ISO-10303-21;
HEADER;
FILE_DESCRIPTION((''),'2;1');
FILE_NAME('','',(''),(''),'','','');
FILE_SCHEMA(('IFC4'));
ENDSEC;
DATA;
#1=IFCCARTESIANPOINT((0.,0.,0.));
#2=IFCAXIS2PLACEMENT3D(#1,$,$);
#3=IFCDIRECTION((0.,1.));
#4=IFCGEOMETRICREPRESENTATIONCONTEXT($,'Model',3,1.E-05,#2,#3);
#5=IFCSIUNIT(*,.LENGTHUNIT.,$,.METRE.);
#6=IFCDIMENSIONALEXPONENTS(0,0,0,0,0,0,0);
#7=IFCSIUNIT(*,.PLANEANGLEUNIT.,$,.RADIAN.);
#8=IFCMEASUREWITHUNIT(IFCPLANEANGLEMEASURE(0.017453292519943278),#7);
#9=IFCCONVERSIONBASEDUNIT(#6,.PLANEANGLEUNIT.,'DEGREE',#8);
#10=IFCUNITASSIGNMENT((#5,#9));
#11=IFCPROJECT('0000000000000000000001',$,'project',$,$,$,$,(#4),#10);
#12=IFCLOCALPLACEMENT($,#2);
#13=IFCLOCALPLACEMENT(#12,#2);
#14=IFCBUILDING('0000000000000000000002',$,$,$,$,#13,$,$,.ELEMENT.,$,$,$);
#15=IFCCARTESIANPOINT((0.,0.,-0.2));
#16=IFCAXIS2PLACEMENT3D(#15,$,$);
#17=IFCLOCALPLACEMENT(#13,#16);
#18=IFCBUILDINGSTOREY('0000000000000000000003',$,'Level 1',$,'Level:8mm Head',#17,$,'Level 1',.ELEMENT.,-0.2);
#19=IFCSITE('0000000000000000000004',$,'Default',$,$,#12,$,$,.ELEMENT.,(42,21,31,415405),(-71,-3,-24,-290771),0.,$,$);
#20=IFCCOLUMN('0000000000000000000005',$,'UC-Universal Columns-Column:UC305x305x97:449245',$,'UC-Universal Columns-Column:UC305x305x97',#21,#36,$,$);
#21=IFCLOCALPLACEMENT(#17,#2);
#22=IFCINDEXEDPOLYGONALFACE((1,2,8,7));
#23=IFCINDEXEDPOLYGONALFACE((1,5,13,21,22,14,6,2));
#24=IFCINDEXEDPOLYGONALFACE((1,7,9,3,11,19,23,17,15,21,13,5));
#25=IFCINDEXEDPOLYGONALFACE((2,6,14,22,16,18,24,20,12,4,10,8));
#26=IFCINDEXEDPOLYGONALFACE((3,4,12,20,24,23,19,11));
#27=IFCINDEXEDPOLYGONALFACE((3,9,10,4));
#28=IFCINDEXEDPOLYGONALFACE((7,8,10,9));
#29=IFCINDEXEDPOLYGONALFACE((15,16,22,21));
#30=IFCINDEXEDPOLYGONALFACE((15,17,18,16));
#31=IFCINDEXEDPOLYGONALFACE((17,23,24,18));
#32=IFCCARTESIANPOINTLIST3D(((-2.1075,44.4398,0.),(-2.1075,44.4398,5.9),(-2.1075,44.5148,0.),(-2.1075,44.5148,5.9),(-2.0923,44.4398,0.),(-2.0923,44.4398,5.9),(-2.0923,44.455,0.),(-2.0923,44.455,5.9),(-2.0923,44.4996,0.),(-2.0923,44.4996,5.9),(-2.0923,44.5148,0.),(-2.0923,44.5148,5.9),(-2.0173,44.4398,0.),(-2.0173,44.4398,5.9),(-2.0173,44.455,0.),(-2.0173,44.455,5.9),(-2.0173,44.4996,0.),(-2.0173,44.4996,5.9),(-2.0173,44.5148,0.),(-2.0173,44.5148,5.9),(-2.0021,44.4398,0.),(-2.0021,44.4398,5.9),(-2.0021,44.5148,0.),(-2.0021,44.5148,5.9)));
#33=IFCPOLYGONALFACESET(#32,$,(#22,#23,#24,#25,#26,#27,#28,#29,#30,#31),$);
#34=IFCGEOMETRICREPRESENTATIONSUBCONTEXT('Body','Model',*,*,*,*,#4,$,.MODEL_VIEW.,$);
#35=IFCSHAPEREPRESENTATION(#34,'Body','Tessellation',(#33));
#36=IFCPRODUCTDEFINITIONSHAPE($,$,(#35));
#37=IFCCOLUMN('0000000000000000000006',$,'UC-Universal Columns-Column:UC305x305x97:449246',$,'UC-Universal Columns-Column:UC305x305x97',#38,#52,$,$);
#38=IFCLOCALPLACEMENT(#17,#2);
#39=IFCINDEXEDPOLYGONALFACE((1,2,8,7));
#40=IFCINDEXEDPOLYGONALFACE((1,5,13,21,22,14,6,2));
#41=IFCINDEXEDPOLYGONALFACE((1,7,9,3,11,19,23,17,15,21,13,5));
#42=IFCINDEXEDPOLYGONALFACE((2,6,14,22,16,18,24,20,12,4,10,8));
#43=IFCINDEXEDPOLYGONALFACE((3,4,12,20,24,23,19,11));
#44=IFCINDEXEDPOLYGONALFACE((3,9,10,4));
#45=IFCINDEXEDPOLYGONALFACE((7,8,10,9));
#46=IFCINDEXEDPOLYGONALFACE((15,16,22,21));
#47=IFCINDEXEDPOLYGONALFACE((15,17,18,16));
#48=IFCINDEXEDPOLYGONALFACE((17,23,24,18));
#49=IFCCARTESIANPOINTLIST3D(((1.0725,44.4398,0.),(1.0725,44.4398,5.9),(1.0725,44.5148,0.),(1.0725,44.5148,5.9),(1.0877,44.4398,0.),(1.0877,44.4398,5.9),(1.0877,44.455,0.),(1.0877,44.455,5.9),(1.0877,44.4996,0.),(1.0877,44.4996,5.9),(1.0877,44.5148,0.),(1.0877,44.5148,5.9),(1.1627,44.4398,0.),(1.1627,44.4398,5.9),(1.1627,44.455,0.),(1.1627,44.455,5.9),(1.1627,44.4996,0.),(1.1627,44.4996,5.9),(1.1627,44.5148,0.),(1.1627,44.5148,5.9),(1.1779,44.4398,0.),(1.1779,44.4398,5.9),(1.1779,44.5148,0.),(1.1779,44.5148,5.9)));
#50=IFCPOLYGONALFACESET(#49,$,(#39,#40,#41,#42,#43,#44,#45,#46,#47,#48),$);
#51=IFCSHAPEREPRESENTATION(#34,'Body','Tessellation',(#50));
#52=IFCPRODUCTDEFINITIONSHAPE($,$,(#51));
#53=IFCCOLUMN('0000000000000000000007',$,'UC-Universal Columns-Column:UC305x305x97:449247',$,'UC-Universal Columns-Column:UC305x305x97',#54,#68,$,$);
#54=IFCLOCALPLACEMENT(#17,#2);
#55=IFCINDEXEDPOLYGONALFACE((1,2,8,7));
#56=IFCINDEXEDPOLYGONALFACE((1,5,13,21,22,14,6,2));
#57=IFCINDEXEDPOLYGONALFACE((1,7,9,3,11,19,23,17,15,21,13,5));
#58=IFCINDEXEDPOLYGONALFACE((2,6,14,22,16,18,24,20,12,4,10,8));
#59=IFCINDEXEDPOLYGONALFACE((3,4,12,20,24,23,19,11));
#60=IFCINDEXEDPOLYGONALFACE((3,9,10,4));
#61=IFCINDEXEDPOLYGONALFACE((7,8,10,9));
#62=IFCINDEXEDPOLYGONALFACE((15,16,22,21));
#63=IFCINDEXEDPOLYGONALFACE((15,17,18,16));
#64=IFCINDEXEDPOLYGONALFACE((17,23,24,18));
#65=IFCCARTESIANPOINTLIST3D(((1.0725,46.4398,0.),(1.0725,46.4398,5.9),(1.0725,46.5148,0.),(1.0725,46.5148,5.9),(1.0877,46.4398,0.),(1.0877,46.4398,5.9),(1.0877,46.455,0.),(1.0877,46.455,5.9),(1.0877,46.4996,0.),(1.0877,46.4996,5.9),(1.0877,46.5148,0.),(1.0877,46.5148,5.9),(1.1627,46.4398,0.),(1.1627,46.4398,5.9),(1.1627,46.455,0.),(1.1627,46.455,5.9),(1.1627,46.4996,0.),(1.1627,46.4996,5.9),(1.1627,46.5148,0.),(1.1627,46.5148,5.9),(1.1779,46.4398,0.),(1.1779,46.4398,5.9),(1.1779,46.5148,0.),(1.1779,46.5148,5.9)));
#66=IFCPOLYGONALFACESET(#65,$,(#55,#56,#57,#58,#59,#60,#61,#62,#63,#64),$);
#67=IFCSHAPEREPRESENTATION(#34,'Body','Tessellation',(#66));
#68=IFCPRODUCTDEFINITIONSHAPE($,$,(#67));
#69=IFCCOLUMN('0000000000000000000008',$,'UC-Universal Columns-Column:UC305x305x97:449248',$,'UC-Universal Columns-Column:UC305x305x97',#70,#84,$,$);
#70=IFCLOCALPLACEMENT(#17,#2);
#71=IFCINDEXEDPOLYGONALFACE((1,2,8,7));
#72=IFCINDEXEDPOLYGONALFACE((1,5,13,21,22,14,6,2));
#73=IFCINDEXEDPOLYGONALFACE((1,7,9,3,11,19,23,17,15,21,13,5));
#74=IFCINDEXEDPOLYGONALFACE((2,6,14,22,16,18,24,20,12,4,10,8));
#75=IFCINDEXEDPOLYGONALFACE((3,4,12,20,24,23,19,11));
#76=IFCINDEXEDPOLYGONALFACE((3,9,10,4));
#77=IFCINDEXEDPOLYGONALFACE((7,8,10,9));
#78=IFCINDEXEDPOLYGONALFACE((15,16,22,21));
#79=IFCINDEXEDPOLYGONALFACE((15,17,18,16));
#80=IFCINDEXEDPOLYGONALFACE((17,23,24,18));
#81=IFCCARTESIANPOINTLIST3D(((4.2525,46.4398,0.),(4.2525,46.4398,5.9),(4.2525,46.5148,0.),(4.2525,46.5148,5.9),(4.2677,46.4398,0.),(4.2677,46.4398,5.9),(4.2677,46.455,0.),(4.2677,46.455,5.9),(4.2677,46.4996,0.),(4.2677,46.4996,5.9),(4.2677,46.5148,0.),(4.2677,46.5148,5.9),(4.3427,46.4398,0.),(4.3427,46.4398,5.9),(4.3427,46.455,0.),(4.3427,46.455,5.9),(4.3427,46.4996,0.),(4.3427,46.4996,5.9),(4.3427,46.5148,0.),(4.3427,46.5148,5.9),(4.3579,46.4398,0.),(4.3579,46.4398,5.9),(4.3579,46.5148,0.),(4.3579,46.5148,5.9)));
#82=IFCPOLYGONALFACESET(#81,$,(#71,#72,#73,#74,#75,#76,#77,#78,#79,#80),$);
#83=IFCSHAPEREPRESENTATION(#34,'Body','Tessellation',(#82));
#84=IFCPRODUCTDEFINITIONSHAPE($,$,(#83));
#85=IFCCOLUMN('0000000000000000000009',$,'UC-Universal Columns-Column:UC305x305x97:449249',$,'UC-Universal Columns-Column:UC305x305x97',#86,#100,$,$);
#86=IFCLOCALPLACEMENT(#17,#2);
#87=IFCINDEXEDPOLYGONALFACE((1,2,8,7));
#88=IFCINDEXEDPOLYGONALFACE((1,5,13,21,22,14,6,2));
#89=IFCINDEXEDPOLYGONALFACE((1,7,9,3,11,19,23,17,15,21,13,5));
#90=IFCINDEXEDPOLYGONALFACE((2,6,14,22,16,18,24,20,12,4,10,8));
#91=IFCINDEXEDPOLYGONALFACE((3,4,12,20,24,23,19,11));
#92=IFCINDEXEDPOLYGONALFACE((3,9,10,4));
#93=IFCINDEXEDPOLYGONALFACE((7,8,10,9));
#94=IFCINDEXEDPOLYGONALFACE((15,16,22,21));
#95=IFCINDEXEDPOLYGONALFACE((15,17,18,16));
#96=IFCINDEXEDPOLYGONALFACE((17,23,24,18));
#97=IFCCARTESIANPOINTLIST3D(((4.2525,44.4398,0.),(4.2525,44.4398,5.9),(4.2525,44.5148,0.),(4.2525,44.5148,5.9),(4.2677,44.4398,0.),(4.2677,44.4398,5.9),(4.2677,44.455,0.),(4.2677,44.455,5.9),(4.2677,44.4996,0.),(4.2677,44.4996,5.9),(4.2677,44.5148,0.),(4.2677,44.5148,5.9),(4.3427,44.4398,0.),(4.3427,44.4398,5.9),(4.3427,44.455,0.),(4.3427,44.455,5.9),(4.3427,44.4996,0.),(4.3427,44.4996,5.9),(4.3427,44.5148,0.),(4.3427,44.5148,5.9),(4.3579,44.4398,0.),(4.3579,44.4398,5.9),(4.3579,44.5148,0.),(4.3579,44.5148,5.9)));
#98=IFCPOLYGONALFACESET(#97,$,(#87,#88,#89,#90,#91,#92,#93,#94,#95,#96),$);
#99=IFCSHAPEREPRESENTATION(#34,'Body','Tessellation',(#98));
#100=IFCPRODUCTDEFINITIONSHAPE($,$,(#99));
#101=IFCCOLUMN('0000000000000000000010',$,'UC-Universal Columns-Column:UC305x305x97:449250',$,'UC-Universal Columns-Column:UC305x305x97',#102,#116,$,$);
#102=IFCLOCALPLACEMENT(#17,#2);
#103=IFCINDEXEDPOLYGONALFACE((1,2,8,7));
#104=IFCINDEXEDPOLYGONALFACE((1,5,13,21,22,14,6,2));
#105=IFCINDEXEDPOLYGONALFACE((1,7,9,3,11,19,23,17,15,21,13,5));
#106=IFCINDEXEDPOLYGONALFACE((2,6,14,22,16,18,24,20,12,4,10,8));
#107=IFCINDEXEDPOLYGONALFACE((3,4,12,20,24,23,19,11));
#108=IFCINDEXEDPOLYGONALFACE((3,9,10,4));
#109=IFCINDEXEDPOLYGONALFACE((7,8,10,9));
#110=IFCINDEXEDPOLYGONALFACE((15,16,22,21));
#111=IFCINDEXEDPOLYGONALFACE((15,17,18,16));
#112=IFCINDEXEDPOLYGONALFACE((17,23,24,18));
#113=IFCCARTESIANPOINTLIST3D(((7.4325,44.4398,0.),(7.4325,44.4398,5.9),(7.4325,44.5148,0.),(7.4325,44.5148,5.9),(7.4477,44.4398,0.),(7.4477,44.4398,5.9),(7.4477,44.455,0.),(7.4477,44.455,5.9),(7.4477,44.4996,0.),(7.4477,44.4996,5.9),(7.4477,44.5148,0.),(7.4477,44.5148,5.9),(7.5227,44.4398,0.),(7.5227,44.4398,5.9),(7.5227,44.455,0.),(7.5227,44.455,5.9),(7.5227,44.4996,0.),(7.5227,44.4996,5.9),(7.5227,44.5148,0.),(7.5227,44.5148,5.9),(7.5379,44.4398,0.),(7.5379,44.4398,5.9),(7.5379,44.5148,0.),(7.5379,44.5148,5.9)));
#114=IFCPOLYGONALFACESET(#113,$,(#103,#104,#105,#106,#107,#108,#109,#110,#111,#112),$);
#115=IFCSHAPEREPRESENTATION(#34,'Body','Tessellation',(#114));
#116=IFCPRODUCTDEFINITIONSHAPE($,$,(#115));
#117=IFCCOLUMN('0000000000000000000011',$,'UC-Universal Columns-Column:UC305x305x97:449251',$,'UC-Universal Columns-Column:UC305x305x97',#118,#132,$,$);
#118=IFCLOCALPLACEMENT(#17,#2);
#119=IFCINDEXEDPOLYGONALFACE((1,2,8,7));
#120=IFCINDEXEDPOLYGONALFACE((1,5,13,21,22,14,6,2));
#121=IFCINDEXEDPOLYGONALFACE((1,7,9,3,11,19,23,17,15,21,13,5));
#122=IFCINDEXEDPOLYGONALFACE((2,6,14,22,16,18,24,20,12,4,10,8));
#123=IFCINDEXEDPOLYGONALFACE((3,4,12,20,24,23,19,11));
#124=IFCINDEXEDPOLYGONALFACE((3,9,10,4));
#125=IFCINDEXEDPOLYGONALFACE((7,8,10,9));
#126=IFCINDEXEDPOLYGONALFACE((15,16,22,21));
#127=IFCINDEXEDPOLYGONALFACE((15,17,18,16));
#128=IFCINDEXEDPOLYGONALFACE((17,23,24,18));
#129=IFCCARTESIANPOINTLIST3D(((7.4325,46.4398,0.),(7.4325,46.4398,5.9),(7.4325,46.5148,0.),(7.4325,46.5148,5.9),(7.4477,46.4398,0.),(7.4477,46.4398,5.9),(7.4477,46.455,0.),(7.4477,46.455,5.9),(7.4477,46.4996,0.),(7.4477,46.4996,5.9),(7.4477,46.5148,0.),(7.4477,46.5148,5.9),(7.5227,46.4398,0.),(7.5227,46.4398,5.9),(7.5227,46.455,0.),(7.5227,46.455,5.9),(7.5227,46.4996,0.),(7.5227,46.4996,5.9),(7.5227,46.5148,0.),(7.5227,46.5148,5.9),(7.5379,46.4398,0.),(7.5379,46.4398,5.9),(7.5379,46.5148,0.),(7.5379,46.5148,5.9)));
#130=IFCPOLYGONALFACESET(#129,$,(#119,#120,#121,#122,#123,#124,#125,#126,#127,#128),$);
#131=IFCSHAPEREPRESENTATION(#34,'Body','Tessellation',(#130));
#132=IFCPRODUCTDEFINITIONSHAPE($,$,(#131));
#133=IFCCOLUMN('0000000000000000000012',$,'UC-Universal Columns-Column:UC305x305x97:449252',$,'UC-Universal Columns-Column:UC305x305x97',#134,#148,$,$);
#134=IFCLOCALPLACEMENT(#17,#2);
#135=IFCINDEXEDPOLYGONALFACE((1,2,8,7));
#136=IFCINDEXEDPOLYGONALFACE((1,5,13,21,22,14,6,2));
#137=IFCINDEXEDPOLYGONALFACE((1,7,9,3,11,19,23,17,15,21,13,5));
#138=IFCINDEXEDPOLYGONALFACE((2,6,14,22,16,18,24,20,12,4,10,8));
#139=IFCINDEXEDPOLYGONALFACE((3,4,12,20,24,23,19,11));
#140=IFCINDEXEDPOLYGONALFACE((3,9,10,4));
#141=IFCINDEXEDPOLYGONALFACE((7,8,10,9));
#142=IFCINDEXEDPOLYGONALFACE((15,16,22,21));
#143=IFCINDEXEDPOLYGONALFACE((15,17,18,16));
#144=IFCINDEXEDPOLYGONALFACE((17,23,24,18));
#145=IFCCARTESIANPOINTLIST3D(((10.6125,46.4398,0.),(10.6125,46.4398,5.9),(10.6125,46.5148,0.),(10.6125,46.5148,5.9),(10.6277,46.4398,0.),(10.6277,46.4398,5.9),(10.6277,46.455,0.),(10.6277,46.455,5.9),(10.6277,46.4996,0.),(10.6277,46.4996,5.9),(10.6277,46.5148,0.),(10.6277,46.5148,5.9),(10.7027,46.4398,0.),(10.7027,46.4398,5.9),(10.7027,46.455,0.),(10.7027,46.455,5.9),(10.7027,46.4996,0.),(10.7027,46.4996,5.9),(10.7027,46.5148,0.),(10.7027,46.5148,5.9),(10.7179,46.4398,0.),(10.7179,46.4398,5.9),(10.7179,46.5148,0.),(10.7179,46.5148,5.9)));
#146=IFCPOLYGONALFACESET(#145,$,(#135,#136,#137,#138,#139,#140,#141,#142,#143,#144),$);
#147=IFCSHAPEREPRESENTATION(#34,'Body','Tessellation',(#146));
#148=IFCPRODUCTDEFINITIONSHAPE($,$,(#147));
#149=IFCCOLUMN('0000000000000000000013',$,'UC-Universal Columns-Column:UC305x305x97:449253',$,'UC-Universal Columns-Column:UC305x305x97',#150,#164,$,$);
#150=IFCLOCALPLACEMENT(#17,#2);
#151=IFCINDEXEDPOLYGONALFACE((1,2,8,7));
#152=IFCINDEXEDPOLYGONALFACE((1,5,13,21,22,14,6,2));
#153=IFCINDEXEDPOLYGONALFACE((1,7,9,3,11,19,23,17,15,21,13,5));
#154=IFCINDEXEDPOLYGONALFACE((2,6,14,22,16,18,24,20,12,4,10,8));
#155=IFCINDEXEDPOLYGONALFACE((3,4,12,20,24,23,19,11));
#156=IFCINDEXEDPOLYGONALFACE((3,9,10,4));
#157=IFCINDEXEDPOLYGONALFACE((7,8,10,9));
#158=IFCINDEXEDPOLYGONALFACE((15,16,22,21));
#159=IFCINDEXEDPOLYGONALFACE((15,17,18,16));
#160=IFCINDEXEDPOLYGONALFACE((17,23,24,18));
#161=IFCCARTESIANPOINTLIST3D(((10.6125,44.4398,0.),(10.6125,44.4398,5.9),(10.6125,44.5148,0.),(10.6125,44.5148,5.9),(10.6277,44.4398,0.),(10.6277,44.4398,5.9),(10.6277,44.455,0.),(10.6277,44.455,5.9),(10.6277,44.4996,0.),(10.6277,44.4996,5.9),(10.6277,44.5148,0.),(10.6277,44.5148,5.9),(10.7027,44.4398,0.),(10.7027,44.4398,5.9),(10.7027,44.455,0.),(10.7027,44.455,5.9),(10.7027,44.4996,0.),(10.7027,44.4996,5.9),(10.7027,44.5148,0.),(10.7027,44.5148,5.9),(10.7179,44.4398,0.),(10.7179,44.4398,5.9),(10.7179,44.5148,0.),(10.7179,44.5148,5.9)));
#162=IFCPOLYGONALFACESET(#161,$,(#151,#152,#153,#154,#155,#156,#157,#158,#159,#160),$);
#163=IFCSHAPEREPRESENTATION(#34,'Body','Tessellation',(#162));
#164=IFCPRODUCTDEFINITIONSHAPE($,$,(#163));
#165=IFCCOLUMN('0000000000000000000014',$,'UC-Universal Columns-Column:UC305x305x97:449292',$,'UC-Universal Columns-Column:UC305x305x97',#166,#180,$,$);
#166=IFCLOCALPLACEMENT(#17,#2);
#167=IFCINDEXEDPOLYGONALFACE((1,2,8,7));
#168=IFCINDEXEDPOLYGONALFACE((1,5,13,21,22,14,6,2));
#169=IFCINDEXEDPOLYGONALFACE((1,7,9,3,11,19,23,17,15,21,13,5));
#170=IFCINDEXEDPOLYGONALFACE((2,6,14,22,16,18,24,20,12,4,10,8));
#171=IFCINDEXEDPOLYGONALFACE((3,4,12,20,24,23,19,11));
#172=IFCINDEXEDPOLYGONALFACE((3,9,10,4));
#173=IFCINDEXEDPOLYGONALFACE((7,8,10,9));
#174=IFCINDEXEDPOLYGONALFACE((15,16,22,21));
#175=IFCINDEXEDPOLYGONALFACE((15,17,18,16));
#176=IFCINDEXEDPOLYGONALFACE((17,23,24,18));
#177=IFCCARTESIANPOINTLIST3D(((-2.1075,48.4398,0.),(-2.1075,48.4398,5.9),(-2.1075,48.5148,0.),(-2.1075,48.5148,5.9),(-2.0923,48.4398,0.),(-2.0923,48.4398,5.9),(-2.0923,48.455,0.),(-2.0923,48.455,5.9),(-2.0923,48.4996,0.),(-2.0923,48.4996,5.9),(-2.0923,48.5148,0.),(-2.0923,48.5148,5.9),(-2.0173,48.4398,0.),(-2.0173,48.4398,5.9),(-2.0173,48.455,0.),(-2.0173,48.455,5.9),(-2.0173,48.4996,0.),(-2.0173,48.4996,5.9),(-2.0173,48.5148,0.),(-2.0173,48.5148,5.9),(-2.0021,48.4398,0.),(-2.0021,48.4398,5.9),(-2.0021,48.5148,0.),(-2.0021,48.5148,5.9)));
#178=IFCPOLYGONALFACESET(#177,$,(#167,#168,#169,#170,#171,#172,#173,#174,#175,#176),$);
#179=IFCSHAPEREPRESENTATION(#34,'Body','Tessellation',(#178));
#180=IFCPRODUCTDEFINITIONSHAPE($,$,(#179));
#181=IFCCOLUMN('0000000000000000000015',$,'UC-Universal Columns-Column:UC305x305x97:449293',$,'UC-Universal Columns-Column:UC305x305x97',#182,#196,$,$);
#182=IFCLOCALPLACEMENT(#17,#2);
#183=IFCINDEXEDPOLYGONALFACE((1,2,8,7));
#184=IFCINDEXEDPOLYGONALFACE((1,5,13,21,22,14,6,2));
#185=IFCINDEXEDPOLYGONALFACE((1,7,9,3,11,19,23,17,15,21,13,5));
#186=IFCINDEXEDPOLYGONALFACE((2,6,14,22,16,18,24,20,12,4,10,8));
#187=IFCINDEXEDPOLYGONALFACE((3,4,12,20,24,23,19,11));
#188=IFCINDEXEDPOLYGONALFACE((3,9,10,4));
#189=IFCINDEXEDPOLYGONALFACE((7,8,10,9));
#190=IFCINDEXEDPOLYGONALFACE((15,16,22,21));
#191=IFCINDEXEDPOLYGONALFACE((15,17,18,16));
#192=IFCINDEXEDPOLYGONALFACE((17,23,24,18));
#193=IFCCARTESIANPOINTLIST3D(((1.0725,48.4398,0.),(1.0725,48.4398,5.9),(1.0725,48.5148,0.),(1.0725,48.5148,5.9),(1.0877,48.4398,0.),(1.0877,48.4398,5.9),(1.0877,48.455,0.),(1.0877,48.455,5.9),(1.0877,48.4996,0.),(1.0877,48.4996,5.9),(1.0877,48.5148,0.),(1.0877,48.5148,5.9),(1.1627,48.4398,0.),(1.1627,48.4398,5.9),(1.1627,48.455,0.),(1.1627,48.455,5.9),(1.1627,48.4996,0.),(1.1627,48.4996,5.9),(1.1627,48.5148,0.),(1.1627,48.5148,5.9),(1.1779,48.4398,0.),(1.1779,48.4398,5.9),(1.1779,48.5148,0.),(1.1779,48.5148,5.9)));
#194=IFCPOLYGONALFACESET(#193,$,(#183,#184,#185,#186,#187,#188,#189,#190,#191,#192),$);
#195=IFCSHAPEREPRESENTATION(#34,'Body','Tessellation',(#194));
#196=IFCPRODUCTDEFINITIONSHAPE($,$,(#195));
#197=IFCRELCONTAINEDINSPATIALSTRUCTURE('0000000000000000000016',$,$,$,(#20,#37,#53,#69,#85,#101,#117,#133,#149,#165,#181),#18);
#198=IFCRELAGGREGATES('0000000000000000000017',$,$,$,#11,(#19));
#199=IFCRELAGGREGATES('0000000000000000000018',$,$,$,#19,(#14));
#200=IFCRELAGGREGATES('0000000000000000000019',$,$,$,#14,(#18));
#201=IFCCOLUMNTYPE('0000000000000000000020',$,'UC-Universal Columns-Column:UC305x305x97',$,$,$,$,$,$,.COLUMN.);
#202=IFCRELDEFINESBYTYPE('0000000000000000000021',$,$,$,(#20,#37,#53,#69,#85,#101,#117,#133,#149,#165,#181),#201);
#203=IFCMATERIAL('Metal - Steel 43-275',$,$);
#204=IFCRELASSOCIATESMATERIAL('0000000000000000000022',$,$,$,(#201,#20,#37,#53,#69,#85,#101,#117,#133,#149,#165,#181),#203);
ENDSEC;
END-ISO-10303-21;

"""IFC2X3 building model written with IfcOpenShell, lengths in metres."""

from ifc_helpers import new_model, entity, si_unit, converted_unit, direction, frame, frame_2d, origin, place, context, subcontext, project, spatial, polyline, circle_curve, parameter, trimmed, segment, composite_curve, outline, extrude, source, transform, mapped, material, type_object, type_shapes, element, save


model = new_model("IFC2X3")

# Units and contexts
model_context = context("Model", 3, precision=1e-05, world=origin(), true_north=direction((0.0, 1.0)))
body_context = subcontext(model_context, "Body", "Model", "MODEL_VIEW")
ifc_project = project(units=[si_unit("LENGTHUNIT", "METRE"), converted_unit("PLANEANGLEUNIT", "DEGREE", entity("IfcPlaneAngleMeasure", 0.017453292519943278), si_unit("PLANEANGLEUNIT", "RADIAN"), dimensions=[0, 0, 0, 0, 0, 0, 0])], contexts=[model_context])

# Site, building, storey
site_placement = place(None, origin())
site = spatial("IfcSite", under=ifc_project, at=site_placement, Name="Default", CompositionType="ELEMENT", RefLatitude=(42, 21, 31, 415405), RefLongitude=(-71, -3, -24, -290771), RefElevation=0.0)
building_placement = place(site_placement, origin())
building = spatial("IfcBuilding", under=site, at=building_placement, CompositionType="ELEMENT")
storey_placement = place(building_placement, frame((0.0, 0.0, -0.2)))
storey = spatial("IfcBuildingStorey", under=building, at=storey_placement, Name="Level 1", ObjectType="Level:8mm Head", LongName="Level 1", CompositionType="ELEMENT", Elevation=-0.2)

# Columns
ifc_material = material(Name="Metal - Steel 43-275")
column_type = type_object("IfcColumnType", Name="UC-Universal Columns-Column:UC305x305x97", PredefinedType="COLUMN", material=ifc_material)
shared_shape = source(origin(), body_context, "Body", "SweptSolid", [
    extrude(outline(composite_curve([segment(polyline([(-0.0375, -0.0375), (0.0375, -0.0375)]), True, "CONTINUOUS"), segment(polyline([(0.0375, -0.0375), (0.0527, -0.0375)]), True, "CONTINUOUS"), segment(trimmed(circle_curve(frame_2d((0.0527, -0.0223), x_axis=(-1.0, 0.0)), 0.0152), [parameter(0.0)], [parameter(90.0)], True, "PARAMETER"), False, "CONTINUOUS"), segment(polyline([(0.0375, -0.0223), (0.0375, 0.0223)]), True, "CONTINUOUS"), segment(trimmed(circle_curve(frame_2d((0.0527, 0.0223), x_axis=(-1.0, 0.0)), 0.0152), [parameter(270.0)], [parameter(0.0)], True, "PARAMETER"), False, "CONTINUOUS"), segment(polyline([(0.0527, 0.0375), (0.0375, 0.0375)]), True, "CONTINUOUS"), segment(polyline([(0.0375, 0.0375), (-0.0375, 0.0375)]), True, "CONTINUOUS"), segment(polyline([(-0.0375, 0.0375), (-0.0527, 0.0375)]), True, "CONTINUOUS"), segment(trimmed(circle_curve(frame_2d((-0.0527, 0.0223), x_axis=(-1.0, 0.0)), 0.0152), [parameter(180.0)], [parameter(270.0)], True, "PARAMETER"), False, "CONTINUOUS"), segment(polyline([(-0.0375, 0.0223), (-0.0375, -0.0223)]), True, "CONTINUOUS"), segment(trimmed(circle_curve(frame_2d((-0.0527, -0.0223), x_axis=(-1.0, 0.0)), 0.0152), [parameter(90.0)], [parameter(180.0)], True, "PARAMETER"), False, "CONTINUOUS"), segment(polyline([(-0.0527, -0.0375), (-0.0375, -0.0375)]), True, "CONTINUOUS")], self_intersect=False)), frame((0.0, 0.0, -0.2), z_axis=(0.0, 0.0, 1.0), x_axis=(-1.0, 0.0, 0.0)), (0.0, 0.0, 1.0), 5.9),
])
type_shapes(column_type, [shared_shape])
for number, where, z_axis, x_axis, name in (
    (1, (-2.0548, 44.4773, 0.2), (0.0, 0.0, 1.0), (-1.0, 0.0, 0.0), "UC-Universal Columns-Column:UC305x305x97:449245"),
    (2, (1.1252, 44.4773, 0.2), (0.0, 0.0, 1.0), (-1.0, 0.0, 0.0), "UC-Universal Columns-Column:UC305x305x97:449246"),
    (3, (1.1252, 46.4773, 0.2), (0.0, 0.0, 1.0), (-1.0, 0.0, 0.0), "UC-Universal Columns-Column:UC305x305x97:449247"),
    (4, (4.3052, 46.4773, 0.2), (0.0, 0.0, 1.0), (-1.0, 0.0, 0.0), "UC-Universal Columns-Column:UC305x305x97:449248"),
    (5, (4.3052, 44.4773, 0.2), (0.0, 0.0, 1.0), (-1.0, 0.0, 0.0), "UC-Universal Columns-Column:UC305x305x97:449249"),
    (6, (7.4852, 44.4773, 0.2), (0.0, 0.0, 1.0), (-1.0, 0.0, 0.0), "UC-Universal Columns-Column:UC305x305x97:449250"),
    (7, (7.4852, 46.4773, 0.2), (0.0, 0.0, 1.0), (-1.0, 0.0, 0.0), "UC-Universal Columns-Column:UC305x305x97:449251"),
    (8, (10.6652, 46.4773, 0.2), (0.0, 0.0, 1.0), (-1.0, 0.0, 0.0), "UC-Universal Columns-Column:UC305x305x97:449252"),
    (9, (10.6652, 44.4773, 0.2), (0.0, 0.0, 1.0), (-1.0, 0.0, 0.0), "UC-Universal Columns-Column:UC305x305x97:449253"),
    (10, (-2.0548, 48.4773, 0.2), (0.0, 0.0, 1.0), (-1.0, 0.0, 0.0), "UC-Universal Columns-Column:UC305x305x97:449292"),
    (11, (1.1252, 48.4773, 0.2), (0.0, 0.0, 1.0), (-1.0, 0.0, 0.0), "UC-Universal Columns-Column:UC305x305x97:449293"),
):
    element("IfcColumn", number, at=place(storey_placement, frame(where, z_axis=z_axis, x_axis=x_axis)), inside=storey, type_object=column_type, material=ifc_material, Name=name, ObjectType="UC-Universal Columns-Column:UC305x305x97", context=body_context, shape_type="MappedRepresentation", body=[
        mapped(shared_shape, transform((0.0, 0.0, 0.0), scale=1.0)),
    ])

save(model, "model.ifc")
